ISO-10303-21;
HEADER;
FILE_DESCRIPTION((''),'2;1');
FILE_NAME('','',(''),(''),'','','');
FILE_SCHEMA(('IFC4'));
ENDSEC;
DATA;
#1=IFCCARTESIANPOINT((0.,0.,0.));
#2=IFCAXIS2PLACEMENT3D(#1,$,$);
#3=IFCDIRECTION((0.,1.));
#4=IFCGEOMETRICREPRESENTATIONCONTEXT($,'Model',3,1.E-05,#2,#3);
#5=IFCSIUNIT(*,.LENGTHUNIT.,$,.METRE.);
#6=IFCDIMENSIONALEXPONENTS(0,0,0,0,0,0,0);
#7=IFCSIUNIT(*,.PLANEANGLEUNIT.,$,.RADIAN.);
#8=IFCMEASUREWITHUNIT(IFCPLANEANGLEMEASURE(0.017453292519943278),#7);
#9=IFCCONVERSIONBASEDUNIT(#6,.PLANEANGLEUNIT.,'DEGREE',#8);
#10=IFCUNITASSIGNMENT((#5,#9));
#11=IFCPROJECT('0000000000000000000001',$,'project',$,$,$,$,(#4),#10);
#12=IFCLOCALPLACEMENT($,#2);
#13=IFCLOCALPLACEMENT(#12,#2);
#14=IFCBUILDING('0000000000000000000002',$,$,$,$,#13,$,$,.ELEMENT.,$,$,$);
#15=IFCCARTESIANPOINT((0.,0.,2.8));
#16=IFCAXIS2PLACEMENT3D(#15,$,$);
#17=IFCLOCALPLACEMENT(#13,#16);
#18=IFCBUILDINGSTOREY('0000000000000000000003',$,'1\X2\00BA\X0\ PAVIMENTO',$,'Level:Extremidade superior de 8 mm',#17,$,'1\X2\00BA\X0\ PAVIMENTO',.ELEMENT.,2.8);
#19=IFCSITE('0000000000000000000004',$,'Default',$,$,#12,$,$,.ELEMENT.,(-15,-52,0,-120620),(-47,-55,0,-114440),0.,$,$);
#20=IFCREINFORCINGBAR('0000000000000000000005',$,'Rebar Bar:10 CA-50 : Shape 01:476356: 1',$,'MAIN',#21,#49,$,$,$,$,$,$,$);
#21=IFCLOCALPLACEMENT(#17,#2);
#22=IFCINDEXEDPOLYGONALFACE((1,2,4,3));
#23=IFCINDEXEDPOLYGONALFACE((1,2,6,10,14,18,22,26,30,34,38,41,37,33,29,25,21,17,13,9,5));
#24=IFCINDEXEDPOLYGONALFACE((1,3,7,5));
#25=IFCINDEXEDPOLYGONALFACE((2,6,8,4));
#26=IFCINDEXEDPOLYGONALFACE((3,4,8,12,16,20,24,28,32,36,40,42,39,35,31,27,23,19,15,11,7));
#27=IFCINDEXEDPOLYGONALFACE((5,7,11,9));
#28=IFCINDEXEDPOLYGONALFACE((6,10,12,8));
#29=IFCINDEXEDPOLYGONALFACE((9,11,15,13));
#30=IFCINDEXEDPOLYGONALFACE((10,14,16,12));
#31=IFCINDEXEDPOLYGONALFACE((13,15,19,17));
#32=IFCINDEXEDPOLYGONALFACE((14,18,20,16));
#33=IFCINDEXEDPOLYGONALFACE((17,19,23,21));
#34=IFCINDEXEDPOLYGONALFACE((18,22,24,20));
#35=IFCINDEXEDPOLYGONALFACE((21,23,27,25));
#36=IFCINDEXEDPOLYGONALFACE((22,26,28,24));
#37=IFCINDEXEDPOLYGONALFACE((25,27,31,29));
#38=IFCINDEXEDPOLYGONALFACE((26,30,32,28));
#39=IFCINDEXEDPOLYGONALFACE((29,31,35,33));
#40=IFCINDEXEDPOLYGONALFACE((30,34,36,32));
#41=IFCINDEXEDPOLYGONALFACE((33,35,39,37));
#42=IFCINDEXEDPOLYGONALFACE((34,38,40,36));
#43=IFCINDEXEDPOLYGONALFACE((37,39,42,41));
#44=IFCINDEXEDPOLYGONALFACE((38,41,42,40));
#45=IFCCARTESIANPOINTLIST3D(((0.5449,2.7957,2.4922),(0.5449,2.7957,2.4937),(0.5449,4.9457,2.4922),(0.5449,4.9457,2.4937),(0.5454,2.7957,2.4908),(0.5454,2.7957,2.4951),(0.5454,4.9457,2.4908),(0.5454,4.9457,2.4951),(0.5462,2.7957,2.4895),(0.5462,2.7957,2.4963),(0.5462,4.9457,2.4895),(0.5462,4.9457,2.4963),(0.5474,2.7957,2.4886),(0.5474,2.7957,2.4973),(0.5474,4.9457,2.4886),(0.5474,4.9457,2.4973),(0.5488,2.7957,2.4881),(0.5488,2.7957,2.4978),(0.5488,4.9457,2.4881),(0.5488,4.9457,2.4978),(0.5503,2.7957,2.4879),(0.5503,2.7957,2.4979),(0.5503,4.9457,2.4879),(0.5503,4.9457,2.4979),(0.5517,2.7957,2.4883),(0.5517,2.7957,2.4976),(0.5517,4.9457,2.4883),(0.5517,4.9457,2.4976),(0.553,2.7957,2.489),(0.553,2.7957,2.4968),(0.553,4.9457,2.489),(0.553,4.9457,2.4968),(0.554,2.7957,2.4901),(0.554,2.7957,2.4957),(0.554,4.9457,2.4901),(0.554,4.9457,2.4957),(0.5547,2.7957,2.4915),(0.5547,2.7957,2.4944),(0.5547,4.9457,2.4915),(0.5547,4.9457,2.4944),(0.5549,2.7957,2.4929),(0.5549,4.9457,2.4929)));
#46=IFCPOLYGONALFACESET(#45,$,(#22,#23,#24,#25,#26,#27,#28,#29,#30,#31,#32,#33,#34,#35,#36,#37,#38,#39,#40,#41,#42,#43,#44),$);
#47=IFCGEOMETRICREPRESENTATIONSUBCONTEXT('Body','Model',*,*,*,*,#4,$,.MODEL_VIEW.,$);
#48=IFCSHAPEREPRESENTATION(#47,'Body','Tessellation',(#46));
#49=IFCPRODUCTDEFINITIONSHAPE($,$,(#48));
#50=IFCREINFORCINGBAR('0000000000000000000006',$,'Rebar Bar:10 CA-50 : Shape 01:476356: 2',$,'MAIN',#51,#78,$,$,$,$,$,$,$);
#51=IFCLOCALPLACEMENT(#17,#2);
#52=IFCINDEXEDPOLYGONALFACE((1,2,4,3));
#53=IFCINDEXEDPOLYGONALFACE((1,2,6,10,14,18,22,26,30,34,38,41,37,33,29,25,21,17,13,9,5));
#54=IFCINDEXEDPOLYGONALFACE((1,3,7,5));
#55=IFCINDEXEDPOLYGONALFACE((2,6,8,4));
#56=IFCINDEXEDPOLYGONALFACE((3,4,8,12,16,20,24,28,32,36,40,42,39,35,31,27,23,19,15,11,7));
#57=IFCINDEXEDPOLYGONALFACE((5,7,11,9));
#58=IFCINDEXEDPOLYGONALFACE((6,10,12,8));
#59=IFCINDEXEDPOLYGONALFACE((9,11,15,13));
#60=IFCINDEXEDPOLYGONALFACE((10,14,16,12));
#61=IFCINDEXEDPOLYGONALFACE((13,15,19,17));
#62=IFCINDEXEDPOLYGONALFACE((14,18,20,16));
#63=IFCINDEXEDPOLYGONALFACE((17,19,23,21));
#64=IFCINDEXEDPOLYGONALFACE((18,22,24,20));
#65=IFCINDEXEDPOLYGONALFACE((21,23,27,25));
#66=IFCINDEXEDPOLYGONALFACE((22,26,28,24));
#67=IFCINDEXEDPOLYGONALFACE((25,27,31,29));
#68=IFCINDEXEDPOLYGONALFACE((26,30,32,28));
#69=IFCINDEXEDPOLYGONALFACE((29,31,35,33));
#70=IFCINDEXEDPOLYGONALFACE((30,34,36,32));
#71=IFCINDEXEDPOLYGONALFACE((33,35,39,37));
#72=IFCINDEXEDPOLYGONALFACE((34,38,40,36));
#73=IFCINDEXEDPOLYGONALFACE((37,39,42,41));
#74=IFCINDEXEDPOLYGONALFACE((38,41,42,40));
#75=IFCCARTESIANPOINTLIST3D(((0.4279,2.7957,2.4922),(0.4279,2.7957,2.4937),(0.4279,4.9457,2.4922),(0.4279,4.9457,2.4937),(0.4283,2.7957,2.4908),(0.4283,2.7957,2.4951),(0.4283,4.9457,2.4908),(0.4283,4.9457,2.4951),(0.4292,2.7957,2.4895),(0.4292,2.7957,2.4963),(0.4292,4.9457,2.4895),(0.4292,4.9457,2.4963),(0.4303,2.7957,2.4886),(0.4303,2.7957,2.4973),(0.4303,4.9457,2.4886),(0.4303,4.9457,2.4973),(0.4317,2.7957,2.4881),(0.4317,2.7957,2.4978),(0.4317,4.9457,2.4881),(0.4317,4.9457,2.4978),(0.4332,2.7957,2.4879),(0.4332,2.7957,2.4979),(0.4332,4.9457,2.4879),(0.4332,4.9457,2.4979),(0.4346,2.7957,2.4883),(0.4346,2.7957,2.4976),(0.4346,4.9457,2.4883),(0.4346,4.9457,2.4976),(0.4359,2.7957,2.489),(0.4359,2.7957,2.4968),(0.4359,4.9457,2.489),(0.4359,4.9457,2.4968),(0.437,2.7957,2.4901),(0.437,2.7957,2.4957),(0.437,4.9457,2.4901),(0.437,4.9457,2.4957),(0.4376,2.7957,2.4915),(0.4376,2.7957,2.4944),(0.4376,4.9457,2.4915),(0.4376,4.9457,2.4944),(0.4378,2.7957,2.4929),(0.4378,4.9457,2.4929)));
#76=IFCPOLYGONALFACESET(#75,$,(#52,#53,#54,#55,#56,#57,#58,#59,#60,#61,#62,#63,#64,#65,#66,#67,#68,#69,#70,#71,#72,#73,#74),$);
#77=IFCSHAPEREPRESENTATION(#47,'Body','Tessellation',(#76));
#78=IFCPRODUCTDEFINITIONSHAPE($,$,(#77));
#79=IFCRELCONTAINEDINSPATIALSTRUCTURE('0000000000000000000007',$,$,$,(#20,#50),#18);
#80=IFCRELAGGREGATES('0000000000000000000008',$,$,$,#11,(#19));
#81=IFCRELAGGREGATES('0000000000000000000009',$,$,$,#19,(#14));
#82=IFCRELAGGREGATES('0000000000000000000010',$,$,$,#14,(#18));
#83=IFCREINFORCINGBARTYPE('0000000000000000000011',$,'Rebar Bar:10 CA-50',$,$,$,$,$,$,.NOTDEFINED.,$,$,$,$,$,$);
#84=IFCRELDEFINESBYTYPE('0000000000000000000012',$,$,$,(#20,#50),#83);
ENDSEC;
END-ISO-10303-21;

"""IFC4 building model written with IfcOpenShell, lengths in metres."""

from ifc_helpers import new_model, entity, si_unit, converted_unit, direction, frame, origin, place, context, subcontext, project, spatial, type_object, element, save


model = new_model("IFC4")

# Units and contexts
model_context = context("Model", 3, precision=1e-05, world=origin(), true_north=direction((0.0, 1.0)))
body_context = subcontext(model_context, "Body", "Model", "MODEL_VIEW")
ifc_project = project(units=[si_unit("LENGTHUNIT", "METRE"), converted_unit("PLANEANGLEUNIT", "DEGREE", entity("IfcPlaneAngleMeasure", 0.017453292519943278), si_unit("PLANEANGLEUNIT", "RADIAN"), dimensions=[0, 0, 0, 0, 0, 0, 0])], contexts=[model_context])

# Site, building, storey
site_placement = place(None, origin())
site = spatial("IfcSite", under=ifc_project, at=site_placement, Name="Default", CompositionType="ELEMENT", RefLatitude=(-15, -52, 0, -120620), RefLongitude=(-47, -55, 0, -114440), RefElevation=0.0)
building_placement = place(site_placement, origin())
building = spatial("IfcBuilding", under=site, at=building_placement, CompositionType="ELEMENT")
storey_placement = place(building_placement, frame((0.0, 0.0, 2.8)))
storey = spatial("IfcBuildingStorey", under=building, at=storey_placement, Name="1º PAVIMENTO", ObjectType="Level:Extremidade superior de 8 mm", LongName="1º PAVIMENTO", CompositionType="ELEMENT", Elevation=2.8)

# Reinforcing bars
reinforcing_bar_type_1 = type_object("IfcReinforcingBarType", Name="Rebar Bar:10 CA-50", PredefinedType="NOTDEFINED")
reinforcing_bar_1_placement = place(storey_placement, origin())
element("IfcReinforcingBar", 1, at=reinforcing_bar_1_placement, inside=storey, type_object=reinforcing_bar_type_1, Name="Rebar Bar:10 CA-50 : Shape 01:476356: 1", ObjectType="MAIN", context=body_context, shape_type="AdvancedSweptSolid", body=[
    entity("IfcSweptDiskSolid", entity("IfcIndexedPolyCurve", entity("IfcCartesianPointList3D", [[0.5499, 2.7957, 2.4929], [0.5499, 4.9457, 2.4929]]), None, False), 0.005, None, 0.0, 1.0),
])
reinforcing_bar_2_placement = place(storey_placement, origin())
element("IfcReinforcingBar", 2, at=reinforcing_bar_2_placement, inside=storey, type_object=reinforcing_bar_type_1, Name="Rebar Bar:10 CA-50 : Shape 01:476356: 2", ObjectType="MAIN", context=body_context, shape_type="AdvancedSweptSolid", body=[
    entity("IfcSweptDiskSolid", entity("IfcIndexedPolyCurve", entity("IfcCartesianPointList3D", [[0.4328, 2.7957, 2.4929], [0.4328, 4.9457, 2.4929]]), None, False), 0.005, None, 0.0, 1.0),
])

save(model, "model.ifc")
